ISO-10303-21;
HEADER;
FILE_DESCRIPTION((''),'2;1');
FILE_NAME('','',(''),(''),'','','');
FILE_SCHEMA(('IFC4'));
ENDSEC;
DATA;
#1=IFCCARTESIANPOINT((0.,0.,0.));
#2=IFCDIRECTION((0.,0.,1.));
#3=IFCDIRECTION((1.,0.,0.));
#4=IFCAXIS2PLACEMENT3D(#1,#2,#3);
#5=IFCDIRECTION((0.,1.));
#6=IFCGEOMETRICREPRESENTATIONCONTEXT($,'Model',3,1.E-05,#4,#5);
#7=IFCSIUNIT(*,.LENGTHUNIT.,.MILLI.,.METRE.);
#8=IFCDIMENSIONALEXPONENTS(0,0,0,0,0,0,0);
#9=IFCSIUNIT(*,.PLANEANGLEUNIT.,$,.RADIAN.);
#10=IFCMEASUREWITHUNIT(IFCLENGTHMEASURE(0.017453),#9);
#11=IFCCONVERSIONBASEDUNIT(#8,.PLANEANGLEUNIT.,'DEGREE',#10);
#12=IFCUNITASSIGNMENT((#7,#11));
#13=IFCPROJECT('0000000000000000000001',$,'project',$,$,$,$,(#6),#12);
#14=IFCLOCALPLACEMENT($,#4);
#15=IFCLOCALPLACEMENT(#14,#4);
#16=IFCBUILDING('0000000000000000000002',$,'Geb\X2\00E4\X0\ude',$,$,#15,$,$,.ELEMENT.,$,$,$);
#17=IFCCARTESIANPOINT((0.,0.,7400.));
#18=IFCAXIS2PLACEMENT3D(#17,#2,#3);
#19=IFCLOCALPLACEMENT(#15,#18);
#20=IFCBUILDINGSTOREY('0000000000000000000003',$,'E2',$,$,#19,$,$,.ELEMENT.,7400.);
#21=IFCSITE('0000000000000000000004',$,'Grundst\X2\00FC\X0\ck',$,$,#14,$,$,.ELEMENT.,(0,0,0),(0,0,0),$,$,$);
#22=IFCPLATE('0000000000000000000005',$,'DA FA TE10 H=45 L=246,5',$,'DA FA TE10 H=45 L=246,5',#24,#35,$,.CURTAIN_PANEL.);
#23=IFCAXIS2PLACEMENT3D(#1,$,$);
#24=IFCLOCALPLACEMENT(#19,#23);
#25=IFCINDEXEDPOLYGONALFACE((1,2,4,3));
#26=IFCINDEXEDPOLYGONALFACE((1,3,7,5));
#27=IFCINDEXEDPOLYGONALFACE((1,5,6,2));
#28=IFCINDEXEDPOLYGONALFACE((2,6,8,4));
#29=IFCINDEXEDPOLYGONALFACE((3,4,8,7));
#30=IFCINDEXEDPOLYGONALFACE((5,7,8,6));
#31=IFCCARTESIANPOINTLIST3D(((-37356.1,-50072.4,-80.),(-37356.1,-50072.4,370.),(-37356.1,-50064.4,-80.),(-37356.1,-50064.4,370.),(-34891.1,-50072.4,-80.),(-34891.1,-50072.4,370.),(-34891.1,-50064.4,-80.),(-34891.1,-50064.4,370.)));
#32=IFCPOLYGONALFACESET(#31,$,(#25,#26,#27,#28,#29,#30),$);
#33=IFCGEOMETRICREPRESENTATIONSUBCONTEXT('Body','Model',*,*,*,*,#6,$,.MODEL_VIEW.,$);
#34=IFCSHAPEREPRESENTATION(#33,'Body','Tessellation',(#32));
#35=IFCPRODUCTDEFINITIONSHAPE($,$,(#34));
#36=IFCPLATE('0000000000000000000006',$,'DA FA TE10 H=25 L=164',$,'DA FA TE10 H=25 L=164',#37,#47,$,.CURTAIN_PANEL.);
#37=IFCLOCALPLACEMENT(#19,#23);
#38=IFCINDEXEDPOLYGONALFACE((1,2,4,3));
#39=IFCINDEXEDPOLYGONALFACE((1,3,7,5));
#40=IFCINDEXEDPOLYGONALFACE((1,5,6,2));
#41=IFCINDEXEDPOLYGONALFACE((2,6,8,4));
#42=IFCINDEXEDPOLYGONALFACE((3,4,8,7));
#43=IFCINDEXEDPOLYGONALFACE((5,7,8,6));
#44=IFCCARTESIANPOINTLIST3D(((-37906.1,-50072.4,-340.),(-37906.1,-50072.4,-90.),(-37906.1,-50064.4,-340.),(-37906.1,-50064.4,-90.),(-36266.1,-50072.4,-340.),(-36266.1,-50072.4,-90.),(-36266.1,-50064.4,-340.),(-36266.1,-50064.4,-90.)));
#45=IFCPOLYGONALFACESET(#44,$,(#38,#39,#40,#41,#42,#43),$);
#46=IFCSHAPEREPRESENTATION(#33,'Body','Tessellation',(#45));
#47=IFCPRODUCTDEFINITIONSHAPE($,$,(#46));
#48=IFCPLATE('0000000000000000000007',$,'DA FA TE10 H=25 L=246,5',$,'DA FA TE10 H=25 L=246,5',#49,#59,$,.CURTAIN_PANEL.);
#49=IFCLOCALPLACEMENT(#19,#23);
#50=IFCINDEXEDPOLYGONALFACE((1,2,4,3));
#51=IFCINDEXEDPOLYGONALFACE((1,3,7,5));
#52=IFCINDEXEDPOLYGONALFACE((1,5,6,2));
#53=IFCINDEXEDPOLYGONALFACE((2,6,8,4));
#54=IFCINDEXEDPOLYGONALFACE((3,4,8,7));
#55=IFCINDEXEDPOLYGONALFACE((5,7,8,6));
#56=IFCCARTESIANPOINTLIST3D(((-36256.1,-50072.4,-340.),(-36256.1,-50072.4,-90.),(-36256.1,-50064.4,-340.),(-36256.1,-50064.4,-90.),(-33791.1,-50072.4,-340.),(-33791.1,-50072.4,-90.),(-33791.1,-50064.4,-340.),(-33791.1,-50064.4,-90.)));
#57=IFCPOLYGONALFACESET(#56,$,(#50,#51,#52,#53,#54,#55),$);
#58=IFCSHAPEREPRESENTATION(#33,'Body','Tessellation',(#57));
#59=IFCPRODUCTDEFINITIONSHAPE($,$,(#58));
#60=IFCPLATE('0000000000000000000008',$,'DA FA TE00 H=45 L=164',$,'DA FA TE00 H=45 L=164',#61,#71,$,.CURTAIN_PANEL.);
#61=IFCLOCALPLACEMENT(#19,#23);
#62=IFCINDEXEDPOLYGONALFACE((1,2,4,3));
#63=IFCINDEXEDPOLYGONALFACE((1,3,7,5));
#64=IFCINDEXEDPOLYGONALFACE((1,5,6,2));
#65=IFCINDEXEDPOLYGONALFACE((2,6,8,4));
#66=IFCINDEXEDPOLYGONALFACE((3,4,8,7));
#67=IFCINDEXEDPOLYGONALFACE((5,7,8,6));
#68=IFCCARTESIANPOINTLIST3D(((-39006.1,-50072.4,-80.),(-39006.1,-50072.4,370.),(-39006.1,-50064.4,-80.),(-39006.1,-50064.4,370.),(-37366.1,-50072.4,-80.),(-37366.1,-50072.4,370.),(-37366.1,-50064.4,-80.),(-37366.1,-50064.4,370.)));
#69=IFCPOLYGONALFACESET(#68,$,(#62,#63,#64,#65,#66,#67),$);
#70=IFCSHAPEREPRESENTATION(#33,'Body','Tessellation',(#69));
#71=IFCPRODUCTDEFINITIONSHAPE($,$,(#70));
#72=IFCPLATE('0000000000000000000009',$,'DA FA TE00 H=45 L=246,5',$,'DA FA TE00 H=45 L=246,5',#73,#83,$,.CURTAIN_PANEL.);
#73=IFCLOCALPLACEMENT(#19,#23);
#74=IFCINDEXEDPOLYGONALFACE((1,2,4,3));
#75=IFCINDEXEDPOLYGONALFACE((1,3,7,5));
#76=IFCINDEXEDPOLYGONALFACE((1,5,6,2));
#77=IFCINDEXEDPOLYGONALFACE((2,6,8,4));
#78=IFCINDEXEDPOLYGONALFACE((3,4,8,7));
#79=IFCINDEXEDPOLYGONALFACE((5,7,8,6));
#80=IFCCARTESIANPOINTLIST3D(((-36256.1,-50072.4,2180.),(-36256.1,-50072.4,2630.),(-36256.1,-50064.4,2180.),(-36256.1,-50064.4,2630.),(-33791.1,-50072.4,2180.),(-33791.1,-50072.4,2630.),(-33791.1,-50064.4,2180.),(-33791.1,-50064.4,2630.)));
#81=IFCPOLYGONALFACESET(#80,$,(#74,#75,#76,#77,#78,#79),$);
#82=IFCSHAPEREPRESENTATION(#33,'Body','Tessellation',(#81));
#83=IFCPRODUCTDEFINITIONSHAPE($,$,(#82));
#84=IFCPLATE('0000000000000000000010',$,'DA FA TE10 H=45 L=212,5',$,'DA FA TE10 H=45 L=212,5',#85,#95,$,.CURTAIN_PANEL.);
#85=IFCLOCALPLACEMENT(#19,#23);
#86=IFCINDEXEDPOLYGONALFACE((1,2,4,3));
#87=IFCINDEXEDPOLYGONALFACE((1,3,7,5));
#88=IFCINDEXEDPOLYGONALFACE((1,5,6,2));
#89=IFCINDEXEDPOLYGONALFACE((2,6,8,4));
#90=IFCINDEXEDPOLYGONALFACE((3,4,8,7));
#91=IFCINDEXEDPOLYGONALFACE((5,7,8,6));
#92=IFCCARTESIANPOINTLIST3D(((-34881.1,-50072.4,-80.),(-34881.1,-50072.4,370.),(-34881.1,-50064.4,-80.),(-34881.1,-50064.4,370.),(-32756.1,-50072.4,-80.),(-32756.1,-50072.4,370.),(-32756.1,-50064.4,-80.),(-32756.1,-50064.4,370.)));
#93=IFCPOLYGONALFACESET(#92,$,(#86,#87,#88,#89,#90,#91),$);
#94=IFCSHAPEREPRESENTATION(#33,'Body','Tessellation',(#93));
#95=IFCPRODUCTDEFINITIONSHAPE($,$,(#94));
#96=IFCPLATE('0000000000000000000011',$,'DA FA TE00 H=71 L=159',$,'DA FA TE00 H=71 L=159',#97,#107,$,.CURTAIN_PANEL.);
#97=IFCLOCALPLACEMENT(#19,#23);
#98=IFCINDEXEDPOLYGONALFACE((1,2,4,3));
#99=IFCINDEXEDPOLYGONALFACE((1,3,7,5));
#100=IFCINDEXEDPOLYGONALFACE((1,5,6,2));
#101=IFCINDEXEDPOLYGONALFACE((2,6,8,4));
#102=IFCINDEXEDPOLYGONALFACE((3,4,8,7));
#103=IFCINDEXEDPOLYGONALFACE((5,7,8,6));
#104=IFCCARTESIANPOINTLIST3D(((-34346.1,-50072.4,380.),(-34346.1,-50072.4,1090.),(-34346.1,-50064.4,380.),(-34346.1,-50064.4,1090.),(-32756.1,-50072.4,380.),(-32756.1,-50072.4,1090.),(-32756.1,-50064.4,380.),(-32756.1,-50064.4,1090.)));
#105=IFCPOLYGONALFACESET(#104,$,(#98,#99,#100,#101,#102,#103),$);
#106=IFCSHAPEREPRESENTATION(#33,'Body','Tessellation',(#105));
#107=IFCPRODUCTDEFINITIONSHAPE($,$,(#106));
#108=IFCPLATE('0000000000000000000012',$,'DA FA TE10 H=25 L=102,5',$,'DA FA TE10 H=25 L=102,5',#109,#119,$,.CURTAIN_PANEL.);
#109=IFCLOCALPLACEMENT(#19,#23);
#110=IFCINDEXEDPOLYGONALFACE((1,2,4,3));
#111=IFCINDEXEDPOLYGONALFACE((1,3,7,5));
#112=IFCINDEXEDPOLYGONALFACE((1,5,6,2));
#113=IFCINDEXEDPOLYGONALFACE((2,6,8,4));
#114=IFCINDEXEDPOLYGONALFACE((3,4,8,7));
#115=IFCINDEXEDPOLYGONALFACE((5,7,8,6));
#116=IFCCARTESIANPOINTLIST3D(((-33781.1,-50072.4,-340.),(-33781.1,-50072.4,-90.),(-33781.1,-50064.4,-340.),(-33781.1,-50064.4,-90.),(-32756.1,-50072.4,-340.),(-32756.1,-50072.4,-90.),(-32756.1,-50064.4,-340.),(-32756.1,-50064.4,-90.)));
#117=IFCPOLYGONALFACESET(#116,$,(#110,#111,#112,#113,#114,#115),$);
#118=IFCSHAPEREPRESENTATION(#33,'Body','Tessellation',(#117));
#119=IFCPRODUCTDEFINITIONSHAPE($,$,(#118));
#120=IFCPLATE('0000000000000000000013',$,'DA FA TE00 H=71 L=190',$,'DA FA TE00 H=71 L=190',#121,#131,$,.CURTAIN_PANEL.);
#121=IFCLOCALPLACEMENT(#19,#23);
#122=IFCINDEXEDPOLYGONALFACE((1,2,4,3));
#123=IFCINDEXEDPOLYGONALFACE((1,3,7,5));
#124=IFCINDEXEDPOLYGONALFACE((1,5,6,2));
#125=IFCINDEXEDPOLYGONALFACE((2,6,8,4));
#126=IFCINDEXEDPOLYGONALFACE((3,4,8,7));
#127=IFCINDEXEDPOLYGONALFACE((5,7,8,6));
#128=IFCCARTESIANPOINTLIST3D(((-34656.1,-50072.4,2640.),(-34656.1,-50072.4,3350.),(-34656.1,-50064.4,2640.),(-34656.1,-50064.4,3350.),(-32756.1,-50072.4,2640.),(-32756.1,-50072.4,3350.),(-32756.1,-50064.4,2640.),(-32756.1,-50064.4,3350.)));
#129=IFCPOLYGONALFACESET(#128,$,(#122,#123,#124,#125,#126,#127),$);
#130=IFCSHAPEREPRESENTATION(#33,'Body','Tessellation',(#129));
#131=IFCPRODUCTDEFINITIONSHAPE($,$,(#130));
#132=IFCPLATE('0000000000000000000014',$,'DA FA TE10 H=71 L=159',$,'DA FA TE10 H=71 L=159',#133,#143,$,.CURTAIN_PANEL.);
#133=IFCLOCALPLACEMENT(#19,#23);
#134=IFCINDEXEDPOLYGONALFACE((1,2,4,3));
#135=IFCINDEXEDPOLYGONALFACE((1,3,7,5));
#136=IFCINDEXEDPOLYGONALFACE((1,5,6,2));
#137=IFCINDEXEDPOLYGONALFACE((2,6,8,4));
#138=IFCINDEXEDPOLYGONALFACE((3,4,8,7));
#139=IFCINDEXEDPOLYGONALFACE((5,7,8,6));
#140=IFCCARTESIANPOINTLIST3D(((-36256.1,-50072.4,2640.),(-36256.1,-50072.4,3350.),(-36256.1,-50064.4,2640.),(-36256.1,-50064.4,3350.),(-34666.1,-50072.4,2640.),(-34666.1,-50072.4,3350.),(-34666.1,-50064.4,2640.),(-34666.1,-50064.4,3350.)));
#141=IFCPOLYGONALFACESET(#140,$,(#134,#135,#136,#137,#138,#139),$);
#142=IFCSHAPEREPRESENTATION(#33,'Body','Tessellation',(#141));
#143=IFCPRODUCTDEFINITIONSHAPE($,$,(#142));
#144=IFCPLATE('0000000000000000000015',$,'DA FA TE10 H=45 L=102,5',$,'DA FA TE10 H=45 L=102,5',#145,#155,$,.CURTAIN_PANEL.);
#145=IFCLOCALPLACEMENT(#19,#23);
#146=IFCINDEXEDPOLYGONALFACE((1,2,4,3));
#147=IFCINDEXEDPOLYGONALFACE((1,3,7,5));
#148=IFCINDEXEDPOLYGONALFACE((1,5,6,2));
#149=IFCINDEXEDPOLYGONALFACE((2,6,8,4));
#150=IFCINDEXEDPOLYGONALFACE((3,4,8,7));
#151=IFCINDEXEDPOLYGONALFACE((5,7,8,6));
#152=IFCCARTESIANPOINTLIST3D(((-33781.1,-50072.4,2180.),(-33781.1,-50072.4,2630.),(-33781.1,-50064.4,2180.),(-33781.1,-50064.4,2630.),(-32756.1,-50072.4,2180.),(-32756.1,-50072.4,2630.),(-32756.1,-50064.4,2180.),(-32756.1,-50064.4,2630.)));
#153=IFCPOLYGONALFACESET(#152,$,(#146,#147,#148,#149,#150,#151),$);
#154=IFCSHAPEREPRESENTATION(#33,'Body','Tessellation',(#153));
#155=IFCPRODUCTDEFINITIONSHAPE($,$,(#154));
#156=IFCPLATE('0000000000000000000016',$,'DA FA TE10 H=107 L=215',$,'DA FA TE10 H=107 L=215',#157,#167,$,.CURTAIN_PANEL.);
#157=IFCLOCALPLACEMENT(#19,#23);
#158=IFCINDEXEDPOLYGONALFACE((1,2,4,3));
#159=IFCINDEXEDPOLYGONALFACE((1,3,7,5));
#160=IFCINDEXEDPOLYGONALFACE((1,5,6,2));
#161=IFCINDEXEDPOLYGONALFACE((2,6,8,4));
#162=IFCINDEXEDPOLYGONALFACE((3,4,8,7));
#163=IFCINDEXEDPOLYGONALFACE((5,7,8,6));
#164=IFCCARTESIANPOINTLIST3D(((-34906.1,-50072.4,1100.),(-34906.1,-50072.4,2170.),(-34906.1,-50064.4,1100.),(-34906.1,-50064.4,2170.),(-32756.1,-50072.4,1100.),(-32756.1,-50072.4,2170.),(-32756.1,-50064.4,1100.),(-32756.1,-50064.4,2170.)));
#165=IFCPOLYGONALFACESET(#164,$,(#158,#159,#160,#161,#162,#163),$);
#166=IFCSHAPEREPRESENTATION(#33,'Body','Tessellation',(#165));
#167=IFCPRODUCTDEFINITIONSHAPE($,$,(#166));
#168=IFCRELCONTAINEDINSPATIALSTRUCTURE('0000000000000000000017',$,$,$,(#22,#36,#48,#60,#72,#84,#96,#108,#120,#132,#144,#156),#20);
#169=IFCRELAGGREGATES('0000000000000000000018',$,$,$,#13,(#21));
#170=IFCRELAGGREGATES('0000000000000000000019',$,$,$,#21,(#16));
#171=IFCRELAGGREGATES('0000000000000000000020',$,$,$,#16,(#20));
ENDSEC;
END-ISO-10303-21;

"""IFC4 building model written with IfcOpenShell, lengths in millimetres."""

from ifc_helpers import new_model, entity, si_unit, converted_unit, direction, frame, origin_with_axes, place, context, subcontext, project, spatial, line, indexed_curve, outline, extrude, source, transform, mapped, element, save


model = new_model("IFC4")

# Units and contexts
model_context = context("Model", 3, precision=1e-05, world=origin_with_axes(), true_north=direction((0.0, 1.0)))
body_context = subcontext(model_context, "Body", "Model", "MODEL_VIEW")
ifc_project = project(units=[si_unit("LENGTHUNIT", "METRE", prefix="MILLI"), converted_unit("PLANEANGLEUNIT", "DEGREE", entity("IfcLengthMeasure", 0.017453), si_unit("PLANEANGLEUNIT", "RADIAN"), dimensions=[0, 0, 0, 0, 0, 0, 0])], contexts=[model_context])

# Site, building, storey
site_placement = place(None, origin_with_axes())
site = spatial("IfcSite", under=ifc_project, at=site_placement, Name="Grundstück", CompositionType="ELEMENT", RefLatitude=(0, 0, 0), RefLongitude=(0, 0, 0))
building_placement = place(site_placement, origin_with_axes())
building = spatial("IfcBuilding", under=site, at=building_placement, Name="Gebäude", CompositionType="ELEMENT")
storey_placement = place(building_placement, frame((0.0, 0.0, 7400.0), z_axis=(0.0, 0.0, 1.0), x_axis=(1.0, 0.0, 0.0)))
storey = spatial("IfcBuildingStorey", under=building, at=storey_placement, Name="E2", CompositionType="ELEMENT", Elevation=7400.0)

# Plates
shared_shape_1 = source(origin_with_axes(), body_context, "Body", "SweptSolid", [
    extrude(outline(indexed_curve([(-1232.5, 0.0), (1232.5, 0.0), (1232.5, 8.0), (-1232.5, 8.0)], segments=[line(1, 2), line(2, 3), line(3, 4), line(4, 1)])), frame((0.0, 0.0, 450.0), z_axis=(0.0, 0.0, 1.0), x_axis=(1.0, 0.0, 0.0)), (0.0, 0.0, -1.0), 450.0),
])
plate_1_placement = place(storey_placement, frame((-36123.6, -50064.4, -80.0), z_axis=(0.0, 0.0, 1.0), x_axis=(-1.0, 0.0, 0.0)))
element("IfcPlate", 1, at=plate_1_placement, inside=storey, Name="DA FA TE10 H=45 L=246,5", ObjectType="DA FA TE10 H=45 L=246,5", PredefinedType="CURTAIN_PANEL", context=body_context, shape_type="MappedRepresentation", body=[
    mapped(shared_shape_1, transform((0.0, 0.0, 0.0), x_axis=(1.0, 0.0, 0.0), y_axis=(0.0, 1.0, 0.0), z_axis=(0.0, 0.0, 1.0), scale=1.0)),
])
shared_shape_2 = source(origin_with_axes(), body_context, "Body", "SweptSolid", [
    extrude(outline(indexed_curve([(-820.0, 0.0), (820.0, 0.0), (820.0, 8.0), (-820.0, 8.0)], segments=[line(1, 2), line(2, 3), line(3, 4), line(4, 1)])), frame((0.0, 0.0, 250.0), z_axis=(0.0, 0.0, 1.0), x_axis=(1.0, 0.0, 0.0)), (0.0, 0.0, -1.0), 250.0),
])
plate_2_placement = place(storey_placement, frame((-37086.1, -50064.4, -340.0), z_axis=(0.0, 0.0, 1.0), x_axis=(-1.0, 0.0, 0.0)))
element("IfcPlate", 2, at=plate_2_placement, inside=storey, Name="DA FA TE10 H=25 L=164", ObjectType="DA FA TE10 H=25 L=164", PredefinedType="CURTAIN_PANEL", context=body_context, shape_type="MappedRepresentation", body=[
    mapped(shared_shape_2, transform((0.0, 0.0, 0.0), x_axis=(1.0, 0.0, 0.0), y_axis=(0.0, 1.0, 0.0), z_axis=(0.0, 0.0, 1.0), scale=1.0)),
])
shared_shape_3 = source(origin_with_axes(), body_context, "Body", "SweptSolid", [
    extrude(outline(indexed_curve([(-1232.5, 0.0), (1232.5, 0.0), (1232.5, 8.0), (-1232.5, 8.0)], segments=[line(1, 2), line(2, 3), line(3, 4), line(4, 1)])), frame((0.0, 0.0, 250.0), z_axis=(0.0, 0.0, 1.0), x_axis=(1.0, 0.0, 0.0)), (0.0, 0.0, -1.0), 250.0),
])
plate_3_placement = place(storey_placement, frame((-35023.6, -50064.4, -340.0), z_axis=(0.0, 0.0, 1.0), x_axis=(-1.0, 0.0, 0.0)))
element("IfcPlate", 3, at=plate_3_placement, inside=storey, Name="DA FA TE10 H=25 L=246,5", ObjectType="DA FA TE10 H=25 L=246,5", PredefinedType="CURTAIN_PANEL", context=body_context, shape_type="MappedRepresentation", body=[
    mapped(shared_shape_3, transform((0.0, 0.0, 0.0), x_axis=(1.0, 0.0, 0.0), y_axis=(0.0, 1.0, 0.0), z_axis=(0.0, 0.0, 1.0), scale=1.0)),
])
shared_shape_4 = source(origin_with_axes(), body_context, "Body", "SweptSolid", [
    extrude(outline(indexed_curve([(-820.0, 0.0), (820.0, 0.0), (820.0, 8.0), (-820.0, 8.0)], segments=[line(1, 2), line(2, 3), line(3, 4), line(4, 1)])), frame((0.0, 0.0, 450.0), z_axis=(0.0, 0.0, 1.0), x_axis=(1.0, 0.0, 0.0)), (0.0, 0.0, -1.0), 450.0),
])
plate_4_placement = place(storey_placement, frame((-38186.1, -50064.4, -80.0), z_axis=(0.0, 0.0, 1.0), x_axis=(-1.0, 0.0, 0.0)))
element("IfcPlate", 4, at=plate_4_placement, inside=storey, Name="DA FA TE00 H=45 L=164", ObjectType="DA FA TE00 H=45 L=164", PredefinedType="CURTAIN_PANEL", context=body_context, shape_type="MappedRepresentation", body=[
    mapped(shared_shape_4, transform((0.0, 0.0, 0.0), x_axis=(1.0, 0.0, 0.0), y_axis=(0.0, 1.0, 0.0), z_axis=(0.0, 0.0, 1.0), scale=1.0)),
])
shared_shape_5 = source(origin_with_axes(), body_context, "Body", "SweptSolid", [
    extrude(outline(indexed_curve([(-1232.5, 0.0), (1232.5, 0.0), (1232.5, 8.0), (-1232.5, 8.0)], segments=[line(1, 2), line(2, 3), line(3, 4), line(4, 1)])), frame((0.0, 0.0, 450.0), z_axis=(0.0, 0.0, 1.0), x_axis=(1.0, 0.0, 0.0)), (0.0, 0.0, -1.0), 450.0),
])
plate_5_placement = place(storey_placement, frame((-35023.6, -50064.4, 2180.0), z_axis=(0.0, 0.0, 1.0), x_axis=(-1.0, 0.0, 0.0)))
element("IfcPlate", 5, at=plate_5_placement, inside=storey, Name="DA FA TE00 H=45 L=246,5", ObjectType="DA FA TE00 H=45 L=246,5", PredefinedType="CURTAIN_PANEL", context=body_context, shape_type="MappedRepresentation", body=[
    mapped(shared_shape_5, transform((0.0, 0.0, 0.0), x_axis=(1.0, 0.0, 0.0), y_axis=(0.0, 1.0, 0.0), z_axis=(0.0, 0.0, 1.0), scale=1.0)),
])
shared_shape_6 = source(origin_with_axes(), body_context, "Body", "SweptSolid", [
    extrude(outline(indexed_curve([(-1062.5, 0.0), (1062.5, 0.0), (1062.5, 8.0), (-1062.5, 8.0)], segments=[line(1, 2), line(2, 3), line(3, 4), line(4, 1)])), frame((0.0, 0.0, 450.0), z_axis=(0.0, 0.0, 1.0), x_axis=(1.0, 0.0, 0.0)), (0.0, 0.0, -1.0), 450.0),
])
plate_6_placement = place(storey_placement, frame((-33818.6, -50064.4, -80.0), z_axis=(0.0, 0.0, 1.0), x_axis=(-1.0, 0.0, 0.0)))
element("IfcPlate", 6, at=plate_6_placement, inside=storey, Name="DA FA TE10 H=45 L=212,5", ObjectType="DA FA TE10 H=45 L=212,5", PredefinedType="CURTAIN_PANEL", context=body_context, shape_type="MappedRepresentation", body=[
    mapped(shared_shape_6, transform((0.0, 0.0, 0.0), x_axis=(1.0, 0.0, 0.0), y_axis=(0.0, 1.0, 0.0), z_axis=(0.0, 0.0, 1.0), scale=1.0)),
])
shared_shape_7 = source(origin_with_axes(), body_context, "Body", "SweptSolid", [
    extrude(outline(indexed_curve([(-795.0, 0.0), (795.0, 0.0), (795.0, 8.0), (-795.0, 8.0)], segments=[line(1, 2), line(2, 3), line(3, 4), line(4, 1)])), frame((0.0, 0.0, 710.0), z_axis=(0.0, 0.0, 1.0), x_axis=(1.0, 0.0, 0.0)), (0.0, 0.0, -1.0), 710.0),
])
plate_7_placement = place(storey_placement, frame((-33551.1, -50064.4, 380.0), z_axis=(0.0, 0.0, 1.0), x_axis=(-1.0, 0.0, 0.0)))
element("IfcPlate", 7, at=plate_7_placement, inside=storey, Name="DA FA TE00 H=71 L=159", ObjectType="DA FA TE00 H=71 L=159", PredefinedType="CURTAIN_PANEL", context=body_context, shape_type="MappedRepresentation", body=[
    mapped(shared_shape_7, transform((0.0, 0.0, 0.0), x_axis=(1.0, 0.0, 0.0), y_axis=(0.0, 1.0, 0.0), z_axis=(0.0, 0.0, 1.0), scale=1.0)),
])
shared_shape_8 = source(origin_with_axes(), body_context, "Body", "SweptSolid", [
    extrude(outline(indexed_curve([(-512.5, 0.0), (512.5, 0.0), (512.5, 8.0), (-512.5, 8.0)], segments=[line(1, 2), line(2, 3), line(3, 4), line(4, 1)])), frame((0.0, 0.0, 250.0), z_axis=(0.0, 0.0, 1.0), x_axis=(1.0, 0.0, 0.0)), (0.0, 0.0, -1.0), 250.0),
])
plate_8_placement = place(storey_placement, frame((-33268.6, -50064.4, -340.0), z_axis=(0.0, 0.0, 1.0), x_axis=(-1.0, 0.0, 0.0)))
element("IfcPlate", 8, at=plate_8_placement, inside=storey, Name="DA FA TE10 H=25 L=102,5", ObjectType="DA FA TE10 H=25 L=102,5", PredefinedType="CURTAIN_PANEL", context=body_context, shape_type="MappedRepresentation", body=[
    mapped(shared_shape_8, transform((0.0, 0.0, 0.0), x_axis=(1.0, 0.0, 0.0), y_axis=(0.0, 1.0, 0.0), z_axis=(0.0, 0.0, 1.0), scale=1.0)),
])
shared_shape_9 = source(origin_with_axes(), body_context, "Body", "SweptSolid", [
    extrude(outline(indexed_curve([(-950.0, 0.0), (950.0, 0.0), (950.0, 8.0), (-950.0, 8.0)], segments=[line(1, 2), line(2, 3), line(3, 4), line(4, 1)])), frame((0.0, 0.0, 710.0), z_axis=(0.0, 0.0, 1.0), x_axis=(1.0, 0.0, 0.0)), (0.0, 0.0, -1.0), 710.0),
])
plate_9_placement = place(storey_placement, frame((-33706.1, -50064.4, 2640.0), z_axis=(0.0, 0.0, 1.0), x_axis=(-1.0, 0.0, 0.0)))
element("IfcPlate", 9, at=plate_9_placement, inside=storey, Name="DA FA TE00 H=71 L=190", ObjectType="DA FA TE00 H=71 L=190", PredefinedType="CURTAIN_PANEL", context=body_context, shape_type="MappedRepresentation", body=[
    mapped(shared_shape_9, transform((0.0, 0.0, 0.0), x_axis=(1.0, 0.0, 0.0), y_axis=(0.0, 1.0, 0.0), z_axis=(0.0, 0.0, 1.0), scale=1.0)),
])
shared_shape_10 = source(origin_with_axes(), body_context, "Body", "SweptSolid", [
    extrude(outline(indexed_curve([(-795.0, 0.0), (795.0, 0.0), (795.0, 8.0), (-795.0, 8.0)], segments=[line(1, 2), line(2, 3), line(3, 4), line(4, 1)])), frame((0.0, 0.0, 710.0), z_axis=(0.0, 0.0, 1.0), x_axis=(1.0, 0.0, 0.0)), (0.0, 0.0, -1.0), 710.0),
])
plate_10_placement = place(storey_placement, frame((-35461.1, -50064.4, 2640.0), z_axis=(0.0, 0.0, 1.0), x_axis=(-1.0, 0.0, 0.0)))
element("IfcPlate", 10, at=plate_10_placement, inside=storey, Name="DA FA TE10 H=71 L=159", ObjectType="DA FA TE10 H=71 L=159", PredefinedType="CURTAIN_PANEL", context=body_context, shape_type="MappedRepresentation", body=[
    mapped(shared_shape_10, transform((0.0, 0.0, 0.0), x_axis=(1.0, 0.0, 0.0), y_axis=(0.0, 1.0, 0.0), z_axis=(0.0, 0.0, 1.0), scale=1.0)),
])
shared_shape_11 = source(origin_with_axes(), body_context, "Body", "SweptSolid", [
    extrude(outline(indexed_curve([(-512.5, 0.0), (512.5, 0.0), (512.5, 8.0), (-512.5, 8.0)], segments=[line(1, 2), line(2, 3), line(3, 4), line(4, 1)])), frame((0.0, 0.0, 450.0), z_axis=(0.0, 0.0, 1.0), x_axis=(1.0, 0.0, 0.0)), (0.0, 0.0, -1.0), 450.0),
])
plate_11_placement = place(storey_placement, frame((-33268.6, -50064.4, 2180.0), z_axis=(0.0, 0.0, 1.0), x_axis=(-1.0, 0.0, 0.0)))
element("IfcPlate", 11, at=plate_11_placement, inside=storey, Name="DA FA TE10 H=45 L=102,5", ObjectType="DA FA TE10 H=45 L=102,5", PredefinedType="CURTAIN_PANEL", context=body_context, shape_type="MappedRepresentation", body=[
    mapped(shared_shape_11, transform((0.0, 0.0, 0.0), x_axis=(1.0, 0.0, 0.0), y_axis=(0.0, 1.0, 0.0), z_axis=(0.0, 0.0, 1.0), scale=1.0)),
])
shared_shape_12 = source(origin_with_axes(), body_context, "Body", "SweptSolid", [
    extrude(outline(indexed_curve([(-1075.0, 0.0), (1075.0, 0.0), (1075.0, 8.0), (-1075.0, 8.0)], segments=[line(1, 2), line(2, 3), line(3, 4), line(4, 1)])), frame((0.0, 0.0, 1070.0), z_axis=(0.0, 0.0, 1.0), x_axis=(1.0, 0.0, 0.0)), (0.0, 0.0, -1.0), 1070.0),
])
plate_12_placement = place(storey_placement, frame((-33831.1, -50064.4, 1100.0), z_axis=(0.0, 0.0, 1.0), x_axis=(-1.0, 0.0, 0.0)))
element("IfcPlate", 12, at=plate_12_placement, inside=storey, Name="DA FA TE10 H=107 L=215", ObjectType="DA FA TE10 H=107 L=215", PredefinedType="CURTAIN_PANEL", context=body_context, shape_type="MappedRepresentation", body=[
    mapped(shared_shape_12, transform((0.0, 0.0, 0.0), x_axis=(1.0, 0.0, 0.0), y_axis=(0.0, 1.0, 0.0), z_axis=(0.0, 0.0, 1.0), scale=1.0)),
])

save(model, "model.ifc")
